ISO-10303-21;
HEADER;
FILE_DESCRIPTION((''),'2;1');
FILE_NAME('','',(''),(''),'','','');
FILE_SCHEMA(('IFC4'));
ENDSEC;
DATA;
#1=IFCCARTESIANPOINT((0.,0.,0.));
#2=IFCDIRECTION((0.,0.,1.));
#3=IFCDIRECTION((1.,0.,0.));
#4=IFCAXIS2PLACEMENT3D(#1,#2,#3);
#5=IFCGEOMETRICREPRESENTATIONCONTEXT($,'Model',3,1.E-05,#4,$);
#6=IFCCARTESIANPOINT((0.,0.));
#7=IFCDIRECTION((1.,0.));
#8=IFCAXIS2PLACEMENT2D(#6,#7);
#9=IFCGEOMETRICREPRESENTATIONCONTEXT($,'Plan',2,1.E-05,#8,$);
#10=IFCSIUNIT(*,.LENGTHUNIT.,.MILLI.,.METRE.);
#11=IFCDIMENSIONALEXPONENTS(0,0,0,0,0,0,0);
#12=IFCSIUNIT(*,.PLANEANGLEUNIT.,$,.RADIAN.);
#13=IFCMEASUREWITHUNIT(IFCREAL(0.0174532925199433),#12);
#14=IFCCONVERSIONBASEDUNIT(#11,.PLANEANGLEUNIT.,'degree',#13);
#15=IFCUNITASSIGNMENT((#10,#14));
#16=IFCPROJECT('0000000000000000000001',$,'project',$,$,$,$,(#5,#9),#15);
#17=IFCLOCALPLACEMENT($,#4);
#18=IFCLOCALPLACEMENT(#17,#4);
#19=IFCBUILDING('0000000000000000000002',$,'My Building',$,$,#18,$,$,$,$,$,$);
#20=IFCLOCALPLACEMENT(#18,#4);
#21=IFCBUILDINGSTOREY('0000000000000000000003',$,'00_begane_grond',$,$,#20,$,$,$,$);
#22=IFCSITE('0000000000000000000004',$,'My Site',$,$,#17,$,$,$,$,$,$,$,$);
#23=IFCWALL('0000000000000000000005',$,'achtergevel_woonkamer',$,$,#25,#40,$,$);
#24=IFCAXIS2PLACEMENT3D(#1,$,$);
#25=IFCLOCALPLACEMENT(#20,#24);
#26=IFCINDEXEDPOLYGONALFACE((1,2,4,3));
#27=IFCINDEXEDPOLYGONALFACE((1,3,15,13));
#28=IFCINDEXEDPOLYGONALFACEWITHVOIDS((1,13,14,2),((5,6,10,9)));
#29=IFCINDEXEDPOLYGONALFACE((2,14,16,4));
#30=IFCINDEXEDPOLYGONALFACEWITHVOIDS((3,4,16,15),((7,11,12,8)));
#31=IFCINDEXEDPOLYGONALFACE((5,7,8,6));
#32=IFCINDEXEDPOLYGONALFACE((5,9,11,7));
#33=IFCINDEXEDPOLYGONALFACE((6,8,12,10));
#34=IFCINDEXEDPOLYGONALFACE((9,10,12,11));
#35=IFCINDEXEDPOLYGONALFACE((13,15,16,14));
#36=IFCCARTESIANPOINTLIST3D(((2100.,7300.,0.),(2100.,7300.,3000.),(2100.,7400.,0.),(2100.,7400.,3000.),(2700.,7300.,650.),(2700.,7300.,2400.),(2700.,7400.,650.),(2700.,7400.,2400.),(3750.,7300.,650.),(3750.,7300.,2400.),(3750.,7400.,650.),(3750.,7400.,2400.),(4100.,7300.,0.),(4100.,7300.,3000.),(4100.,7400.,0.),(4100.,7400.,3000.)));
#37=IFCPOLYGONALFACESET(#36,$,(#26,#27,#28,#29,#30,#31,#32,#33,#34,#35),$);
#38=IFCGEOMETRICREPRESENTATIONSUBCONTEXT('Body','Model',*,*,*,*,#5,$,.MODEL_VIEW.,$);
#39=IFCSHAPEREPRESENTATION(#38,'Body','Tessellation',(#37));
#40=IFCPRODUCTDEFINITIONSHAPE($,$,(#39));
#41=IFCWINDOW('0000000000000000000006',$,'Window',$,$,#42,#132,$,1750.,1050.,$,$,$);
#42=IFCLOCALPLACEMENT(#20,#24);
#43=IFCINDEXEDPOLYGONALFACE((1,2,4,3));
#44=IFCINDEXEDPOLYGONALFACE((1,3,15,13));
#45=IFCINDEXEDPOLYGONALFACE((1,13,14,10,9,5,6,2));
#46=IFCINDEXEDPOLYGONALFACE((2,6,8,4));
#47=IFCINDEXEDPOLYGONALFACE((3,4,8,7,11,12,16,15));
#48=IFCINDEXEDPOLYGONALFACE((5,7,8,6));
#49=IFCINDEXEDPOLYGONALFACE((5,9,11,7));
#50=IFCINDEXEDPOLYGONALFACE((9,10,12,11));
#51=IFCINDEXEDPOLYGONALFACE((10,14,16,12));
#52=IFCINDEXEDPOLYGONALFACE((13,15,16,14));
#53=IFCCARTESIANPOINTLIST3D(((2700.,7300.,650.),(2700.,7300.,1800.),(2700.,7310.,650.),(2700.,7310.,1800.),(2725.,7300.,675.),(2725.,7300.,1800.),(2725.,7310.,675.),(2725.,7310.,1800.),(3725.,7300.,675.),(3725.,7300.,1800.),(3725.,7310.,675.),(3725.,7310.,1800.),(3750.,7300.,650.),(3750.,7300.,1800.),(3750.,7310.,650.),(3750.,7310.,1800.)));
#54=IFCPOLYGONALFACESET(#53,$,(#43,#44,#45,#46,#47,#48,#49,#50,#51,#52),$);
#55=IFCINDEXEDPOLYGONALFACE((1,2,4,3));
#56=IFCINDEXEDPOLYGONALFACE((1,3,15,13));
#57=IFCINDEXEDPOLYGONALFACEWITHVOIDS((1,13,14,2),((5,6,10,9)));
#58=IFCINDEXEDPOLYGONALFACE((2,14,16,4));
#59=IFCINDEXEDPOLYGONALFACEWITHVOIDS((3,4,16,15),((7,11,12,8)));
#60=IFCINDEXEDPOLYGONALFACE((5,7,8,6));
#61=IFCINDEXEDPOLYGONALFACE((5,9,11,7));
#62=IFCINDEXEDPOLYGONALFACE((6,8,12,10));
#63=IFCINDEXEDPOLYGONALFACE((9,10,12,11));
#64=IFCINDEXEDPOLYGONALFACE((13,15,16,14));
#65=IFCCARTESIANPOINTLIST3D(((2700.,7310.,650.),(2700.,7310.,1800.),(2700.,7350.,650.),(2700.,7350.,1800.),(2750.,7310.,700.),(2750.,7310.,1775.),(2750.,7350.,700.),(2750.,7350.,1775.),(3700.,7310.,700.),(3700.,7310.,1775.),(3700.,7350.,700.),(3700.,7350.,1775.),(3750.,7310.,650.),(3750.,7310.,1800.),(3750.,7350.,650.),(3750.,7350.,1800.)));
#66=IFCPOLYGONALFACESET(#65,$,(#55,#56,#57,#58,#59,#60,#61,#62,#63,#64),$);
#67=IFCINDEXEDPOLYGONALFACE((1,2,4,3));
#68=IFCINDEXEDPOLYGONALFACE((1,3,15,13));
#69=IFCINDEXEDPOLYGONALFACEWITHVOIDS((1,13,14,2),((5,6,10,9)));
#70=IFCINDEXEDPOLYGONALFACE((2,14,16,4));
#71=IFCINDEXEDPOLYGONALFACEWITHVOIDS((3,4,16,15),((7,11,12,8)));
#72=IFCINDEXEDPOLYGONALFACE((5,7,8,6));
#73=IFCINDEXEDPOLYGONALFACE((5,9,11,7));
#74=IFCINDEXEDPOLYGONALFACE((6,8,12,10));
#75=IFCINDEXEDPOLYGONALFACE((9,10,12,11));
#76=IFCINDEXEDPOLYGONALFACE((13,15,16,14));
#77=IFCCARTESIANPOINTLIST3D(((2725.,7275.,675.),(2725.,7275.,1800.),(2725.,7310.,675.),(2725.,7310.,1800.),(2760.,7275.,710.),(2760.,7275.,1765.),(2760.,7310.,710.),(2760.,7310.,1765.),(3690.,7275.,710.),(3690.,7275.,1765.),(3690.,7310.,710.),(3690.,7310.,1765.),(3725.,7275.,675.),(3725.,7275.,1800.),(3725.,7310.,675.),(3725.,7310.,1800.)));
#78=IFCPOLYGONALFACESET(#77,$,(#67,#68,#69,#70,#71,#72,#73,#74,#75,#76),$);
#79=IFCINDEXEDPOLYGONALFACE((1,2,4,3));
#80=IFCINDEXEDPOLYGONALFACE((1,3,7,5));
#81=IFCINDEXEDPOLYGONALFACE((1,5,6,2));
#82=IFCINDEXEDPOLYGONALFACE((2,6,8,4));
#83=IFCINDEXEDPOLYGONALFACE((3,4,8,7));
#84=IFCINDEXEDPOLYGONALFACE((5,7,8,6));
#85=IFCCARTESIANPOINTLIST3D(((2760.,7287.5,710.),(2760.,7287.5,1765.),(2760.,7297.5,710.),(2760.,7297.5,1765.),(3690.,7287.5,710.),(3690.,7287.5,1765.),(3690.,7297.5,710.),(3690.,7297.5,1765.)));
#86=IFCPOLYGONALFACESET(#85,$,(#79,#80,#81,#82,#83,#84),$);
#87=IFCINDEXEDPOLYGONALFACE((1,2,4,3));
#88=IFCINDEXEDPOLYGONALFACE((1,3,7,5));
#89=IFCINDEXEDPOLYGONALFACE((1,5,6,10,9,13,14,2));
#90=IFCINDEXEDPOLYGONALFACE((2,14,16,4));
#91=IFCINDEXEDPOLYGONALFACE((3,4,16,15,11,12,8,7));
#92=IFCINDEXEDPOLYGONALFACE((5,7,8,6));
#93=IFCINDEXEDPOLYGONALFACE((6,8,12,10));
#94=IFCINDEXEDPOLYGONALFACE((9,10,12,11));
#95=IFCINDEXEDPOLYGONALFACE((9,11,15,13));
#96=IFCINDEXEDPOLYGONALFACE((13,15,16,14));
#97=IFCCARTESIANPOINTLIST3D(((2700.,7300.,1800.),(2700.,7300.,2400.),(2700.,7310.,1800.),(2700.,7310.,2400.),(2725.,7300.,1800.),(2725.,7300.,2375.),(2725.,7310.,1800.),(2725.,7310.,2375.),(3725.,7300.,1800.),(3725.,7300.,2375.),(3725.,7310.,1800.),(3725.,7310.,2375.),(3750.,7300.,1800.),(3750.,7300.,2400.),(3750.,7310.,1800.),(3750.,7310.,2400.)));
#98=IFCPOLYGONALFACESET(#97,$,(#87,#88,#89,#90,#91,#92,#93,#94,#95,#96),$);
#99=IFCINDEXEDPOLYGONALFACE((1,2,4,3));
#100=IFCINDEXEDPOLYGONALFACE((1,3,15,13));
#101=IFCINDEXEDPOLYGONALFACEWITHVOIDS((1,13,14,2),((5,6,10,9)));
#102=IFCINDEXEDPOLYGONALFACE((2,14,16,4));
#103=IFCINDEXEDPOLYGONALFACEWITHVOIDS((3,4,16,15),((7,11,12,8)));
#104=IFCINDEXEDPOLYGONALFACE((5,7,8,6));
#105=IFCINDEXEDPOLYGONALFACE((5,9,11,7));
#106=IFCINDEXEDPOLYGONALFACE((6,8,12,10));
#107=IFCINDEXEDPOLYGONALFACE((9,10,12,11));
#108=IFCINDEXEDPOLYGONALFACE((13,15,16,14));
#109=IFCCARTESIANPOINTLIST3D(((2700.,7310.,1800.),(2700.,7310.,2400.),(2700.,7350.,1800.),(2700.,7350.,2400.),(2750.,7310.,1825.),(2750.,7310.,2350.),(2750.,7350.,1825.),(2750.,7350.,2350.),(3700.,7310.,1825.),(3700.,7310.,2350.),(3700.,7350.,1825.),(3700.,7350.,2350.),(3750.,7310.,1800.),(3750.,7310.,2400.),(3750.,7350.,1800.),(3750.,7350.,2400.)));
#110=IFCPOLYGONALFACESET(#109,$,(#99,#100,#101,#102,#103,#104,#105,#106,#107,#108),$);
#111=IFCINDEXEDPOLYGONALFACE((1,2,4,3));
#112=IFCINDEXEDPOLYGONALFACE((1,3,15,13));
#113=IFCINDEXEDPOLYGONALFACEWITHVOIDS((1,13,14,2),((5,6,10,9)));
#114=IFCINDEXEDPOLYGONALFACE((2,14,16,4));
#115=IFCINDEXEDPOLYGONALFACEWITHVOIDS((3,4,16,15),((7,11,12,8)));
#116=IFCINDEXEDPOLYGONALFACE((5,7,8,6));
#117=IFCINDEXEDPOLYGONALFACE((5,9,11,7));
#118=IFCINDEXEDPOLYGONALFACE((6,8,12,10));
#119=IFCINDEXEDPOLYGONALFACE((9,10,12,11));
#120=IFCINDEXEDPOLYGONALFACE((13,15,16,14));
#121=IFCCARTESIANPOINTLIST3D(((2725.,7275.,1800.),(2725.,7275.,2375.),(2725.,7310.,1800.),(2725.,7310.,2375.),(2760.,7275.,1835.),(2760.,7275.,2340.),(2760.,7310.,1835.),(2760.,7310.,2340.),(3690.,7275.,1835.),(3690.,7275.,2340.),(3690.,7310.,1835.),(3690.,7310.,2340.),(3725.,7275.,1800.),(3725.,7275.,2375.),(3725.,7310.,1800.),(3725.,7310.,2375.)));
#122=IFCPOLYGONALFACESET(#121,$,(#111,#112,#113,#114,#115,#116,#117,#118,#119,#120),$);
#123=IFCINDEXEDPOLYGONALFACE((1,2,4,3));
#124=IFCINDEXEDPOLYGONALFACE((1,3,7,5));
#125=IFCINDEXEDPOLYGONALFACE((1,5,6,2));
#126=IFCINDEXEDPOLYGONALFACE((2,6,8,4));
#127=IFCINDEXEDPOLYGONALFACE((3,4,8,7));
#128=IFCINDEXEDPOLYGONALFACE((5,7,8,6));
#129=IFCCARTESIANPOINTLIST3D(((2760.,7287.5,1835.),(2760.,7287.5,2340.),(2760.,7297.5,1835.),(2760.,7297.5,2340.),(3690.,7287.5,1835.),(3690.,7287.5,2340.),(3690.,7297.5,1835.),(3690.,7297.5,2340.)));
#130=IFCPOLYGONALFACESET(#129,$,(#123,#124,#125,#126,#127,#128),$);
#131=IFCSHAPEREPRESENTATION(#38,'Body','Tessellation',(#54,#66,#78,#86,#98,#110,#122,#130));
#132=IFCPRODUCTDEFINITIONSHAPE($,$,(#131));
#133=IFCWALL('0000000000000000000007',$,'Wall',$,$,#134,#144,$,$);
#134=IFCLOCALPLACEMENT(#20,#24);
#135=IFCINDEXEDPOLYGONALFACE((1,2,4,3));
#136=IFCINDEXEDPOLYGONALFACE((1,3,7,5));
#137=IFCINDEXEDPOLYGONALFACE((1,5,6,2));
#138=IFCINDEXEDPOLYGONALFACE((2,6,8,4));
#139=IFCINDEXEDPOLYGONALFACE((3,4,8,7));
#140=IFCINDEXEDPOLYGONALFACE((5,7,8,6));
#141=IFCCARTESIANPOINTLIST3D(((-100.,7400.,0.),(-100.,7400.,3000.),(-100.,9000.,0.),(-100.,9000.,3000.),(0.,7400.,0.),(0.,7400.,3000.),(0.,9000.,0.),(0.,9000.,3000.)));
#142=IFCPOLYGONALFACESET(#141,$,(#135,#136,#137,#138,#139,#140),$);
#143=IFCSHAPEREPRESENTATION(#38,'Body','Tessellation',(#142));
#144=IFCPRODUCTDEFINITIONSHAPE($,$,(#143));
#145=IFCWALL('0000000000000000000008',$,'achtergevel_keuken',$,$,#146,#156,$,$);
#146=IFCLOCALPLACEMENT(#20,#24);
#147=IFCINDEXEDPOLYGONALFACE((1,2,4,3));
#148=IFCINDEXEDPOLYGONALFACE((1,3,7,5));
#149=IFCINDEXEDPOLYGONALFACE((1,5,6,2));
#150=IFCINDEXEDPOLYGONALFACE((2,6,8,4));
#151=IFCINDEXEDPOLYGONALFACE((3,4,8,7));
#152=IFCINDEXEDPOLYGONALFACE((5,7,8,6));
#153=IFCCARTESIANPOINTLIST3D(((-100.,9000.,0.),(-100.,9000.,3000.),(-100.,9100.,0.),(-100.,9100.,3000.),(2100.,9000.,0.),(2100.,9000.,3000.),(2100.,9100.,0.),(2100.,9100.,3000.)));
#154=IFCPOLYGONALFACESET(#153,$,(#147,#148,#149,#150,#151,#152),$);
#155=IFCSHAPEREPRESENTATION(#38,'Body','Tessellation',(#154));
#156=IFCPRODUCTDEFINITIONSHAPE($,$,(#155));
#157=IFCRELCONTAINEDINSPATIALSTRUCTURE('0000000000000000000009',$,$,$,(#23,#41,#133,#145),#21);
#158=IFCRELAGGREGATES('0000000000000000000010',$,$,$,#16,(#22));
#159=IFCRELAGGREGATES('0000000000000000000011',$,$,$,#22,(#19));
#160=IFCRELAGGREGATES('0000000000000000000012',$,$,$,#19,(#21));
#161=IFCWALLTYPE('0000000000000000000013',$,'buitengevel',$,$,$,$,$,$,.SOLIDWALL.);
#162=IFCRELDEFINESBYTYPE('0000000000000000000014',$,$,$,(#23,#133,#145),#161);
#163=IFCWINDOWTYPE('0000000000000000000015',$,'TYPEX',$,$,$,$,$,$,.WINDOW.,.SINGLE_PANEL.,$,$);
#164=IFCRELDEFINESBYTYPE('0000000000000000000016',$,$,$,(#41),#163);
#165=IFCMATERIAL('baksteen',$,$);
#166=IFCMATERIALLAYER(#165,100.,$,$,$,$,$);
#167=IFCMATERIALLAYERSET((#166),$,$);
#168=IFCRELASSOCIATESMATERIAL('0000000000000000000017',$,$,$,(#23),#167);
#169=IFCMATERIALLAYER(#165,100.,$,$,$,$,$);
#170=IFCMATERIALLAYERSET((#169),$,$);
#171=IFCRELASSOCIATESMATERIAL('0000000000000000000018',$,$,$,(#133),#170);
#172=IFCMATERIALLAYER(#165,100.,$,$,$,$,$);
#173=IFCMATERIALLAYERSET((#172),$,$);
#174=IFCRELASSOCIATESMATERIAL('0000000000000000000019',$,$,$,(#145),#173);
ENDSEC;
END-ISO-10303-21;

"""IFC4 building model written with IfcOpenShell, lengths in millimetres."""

from ifc_helpers import new_model, entity, si_unit, converted_unit, frame, origin_with_axes, origin_2d_with_axis, place, context, subcontext, project, spatial, line, indexed_curve, outline, extrude, shape, source, transform, mapped, material, layer, layer_set, type_object, type_shapes, element, fill, save


model = new_model("IFC4")

# Units and contexts
model_context = context("Model", 3, precision=1e-05, world=origin_with_axes())
plan_context = context("Plan", 2, precision=1e-05, world=origin_2d_with_axis())
body_context_1 = subcontext(model_context, "Body", "Model", "MODEL_VIEW")
body_context_2 = subcontext(plan_context, "Body", "Plan", "PLAN_VIEW")
ifc_project = project(units=[si_unit("LENGTHUNIT", "METRE", prefix="MILLI"), converted_unit("PLANEANGLEUNIT", "degree", entity("IfcReal", 0.0174532925199433), si_unit("PLANEANGLEUNIT", "RADIAN"), dimensions=[0, 0, 0, 0, 0, 0, 0])], contexts=[model_context, plan_context])

# Site, building, storey
site_placement = place(None, origin_with_axes())
site = spatial("IfcSite", under=ifc_project, at=site_placement, Name="My Site")
building_placement = place(site_placement, origin_with_axes())
building = spatial("IfcBuilding", under=site, at=building_placement, Name="My Building")
storey_placement = place(building_placement, origin_with_axes())
storey = spatial("IfcBuildingStorey", under=building, at=storey_placement, Name="00_begane_grond")

# Wall, opening, window
ifc_material_1 = material(Name="baksteen")
ifc_layer_1 = layer(ifc_material_1, 100.0)
ifc_layer_set_1 = layer_set([ifc_layer_1])
wall_type_1 = type_object("IfcWallType", Name="buitengevel", PredefinedType="SOLIDWALL")
wall_1_placement = place(storey_placement, frame((4100.0, 7400.0, 0.0), z_axis=(0.0, 0.0, 1.0), x_axis=(-1.0, 0.0, 0.0)))
wall_1 = element("IfcWall", 1, at=wall_1_placement, inside=storey, type_object=wall_type_1, material=ifc_layer_set_1, Name="achtergevel_woonkamer", context=body_context_1, shape_type="SweptSolid", body=[
    extrude(outline(indexed_curve([(0.0, 0.0), (0.0, 100.0), (2000.0, 100.0), (2000.0, 0.0), (0.0, 0.0)], self_intersect=False)), origin_with_axes(), (0.0, 0.0, 1.0), 3000.0),
])
shared_shape_1 = source(origin_with_axes(), body_context_1, "Body", "SweptSolid", [
    extrude(outline(indexed_curve([(0.0, 0.0), (1050.0, 0.0), (1050.0, 1750.0), (0.0, 1750.0)], segments=[line(1, 2, 3, 4, 1)])), frame((0.0, -100.0, 0.0), z_axis=(0.0, -1.0, 0.0), x_axis=(1.0, 0.0, 0.0)), (0.0, 0.0, -1.0), 300.0),
])
opening_1_placement = place(wall_1_placement, frame((350.0, 0.0, 650.0), z_axis=(0.0, 0.0, 1.0), x_axis=(1.0, 0.0, 0.0)))
opening_1 = element("IfcOpeningElement", 2, at=opening_1_placement, cuts=wall_1, PredefinedType="OPENING", context=body_context_1, shape_type="MappedRepresentation", body=[
    mapped(shared_shape_1, transform((0.0, 0.0, 0.0), x_axis=(1.0, 0.0, 0.0), y_axis=(0.0, 1.0, 0.0), z_axis=(0.0, 0.0, 1.0), scale=1.0)),
])
window_type_1 = type_object("IfcWindowType", Name="TYPEX", PartitioningType="SINGLE_PANEL", PredefinedType="WINDOW")
shared_shape_2 = source(origin_with_axes(), body_context_1, "Body", "SweptSolid", [
    extrude(outline(indexed_curve([(1050.0, 1150.0), (1050.0, 0.0), (0.0, 0.0), (0.0, 1150.0), (25.0, 1150.0), (25.0, 25.0), (1025.0, 25.0), (1025.0, 1150.0)], segments=[line(1, 2, 3, 4, 5, 6, 7, 8, 1)])), frame((0.0, 90.0, 0.0), z_axis=(0.0, -1.0, 0.0), x_axis=(1.0, 0.0, 0.0)), (0.0, 0.0, -1.0), 10.0),
    extrude(outline(indexed_curve([(0.0, 0.0), (1050.0, 0.0), (1050.0, 1150.0), (0.0, 1150.0)], segments=[line(1, 2, 3, 4, 1)]), holes=[indexed_curve([(50.0, 50.0), (1000.0, 50.0), (1000.0, 1125.0), (50.0, 1125.0)], segments=[line(1, 2, 3, 4, 1)])]), frame((0.0, 50.0, 0.0), z_axis=(0.0, -1.0, 0.0), x_axis=(1.0, 0.0, 0.0)), (0.0, 0.0, -1.0), 40.0),
    extrude(outline(indexed_curve([(0.0, 0.0), (1000.0, 0.0), (1000.0, 1125.0), (0.0, 1125.0)], segments=[line(1, 2, 3, 4, 1)]), holes=[indexed_curve([(35.0, 35.0), (965.0, 35.0), (965.0, 1090.0), (35.0, 1090.0)], segments=[line(1, 2, 3, 4, 1)])]), frame((25.0, 90.0, 25.0), z_axis=(0.0, -1.0, 0.0), x_axis=(1.0, 0.0, 0.0)), (0.0, 0.0, -1.0), 35.0),
    extrude(outline(indexed_curve([(35.0, 35.0), (965.0, 35.0), (965.0, 1090.0), (35.0, 1090.0)], segments=[line(1, 2, 3, 4, 1)])), frame((25.0, 102.5, 25.0), z_axis=(0.0, -1.0, 0.0), x_axis=(1.0, 0.0, 0.0)), (0.0, 0.0, -1.0), 10.0),
    extrude(outline(indexed_curve([(0.0, 0.0), (0.0, 600.0), (1050.0, 600.0), (1050.0, 0.0), (1025.0, 0.0), (1025.0, 575.0), (25.0, 575.0), (25.0, 0.0)], segments=[line(1, 2, 3, 4, 5, 6, 7, 8, 1)])), frame((0.0, 90.0, 1150.0), z_axis=(0.0, -1.0, 0.0), x_axis=(1.0, 0.0, 0.0)), (0.0, 0.0, -1.0), 10.0),
    extrude(outline(indexed_curve([(0.0, 0.0), (1050.0, 0.0), (1050.0, 600.0), (0.0, 600.0)], segments=[line(1, 2, 3, 4, 1)]), holes=[indexed_curve([(50.0, 25.0), (1000.0, 25.0), (1000.0, 550.0), (50.0, 550.0)], segments=[line(1, 2, 3, 4, 1)])]), frame((0.0, 50.0, 1150.0), z_axis=(0.0, -1.0, 0.0), x_axis=(1.0, 0.0, 0.0)), (0.0, 0.0, -1.0), 40.0),
    extrude(outline(indexed_curve([(0.0, 0.0), (1000.0, 0.0), (1000.0, 575.0), (0.0, 575.0)], segments=[line(1, 2, 3, 4, 1)]), holes=[indexed_curve([(35.0, 35.0), (965.0, 35.0), (965.0, 540.0), (35.0, 540.0)], segments=[line(1, 2, 3, 4, 1)])]), frame((25.0, 90.0, 1150.0), z_axis=(0.0, -1.0, 0.0), x_axis=(1.0, 0.0, 0.0)), (0.0, 0.0, -1.0), 35.0),
    extrude(outline(indexed_curve([(35.0, 35.0), (965.0, 35.0), (965.0, 540.0), (35.0, 540.0)], segments=[line(1, 2, 3, 4, 1)])), frame((25.0, 102.5, 1150.0), z_axis=(0.0, -1.0, 0.0), x_axis=(1.0, 0.0, 0.0)), (0.0, 0.0, -1.0), 10.0),
])
shared_shape_3 = source(origin_with_axes(), body_context_2, "Body", "Curve2D", [
    entity("IfcIndexedPolyCurve", entity("IfcCartesianPointList2D", [[50.0, 50.0], [1000.0, 50.0]])),
    entity("IfcIndexedPolyCurve", entity("IfcCartesianPointList2D", [[0.0, 100.0], [25.0, 100.0], [25.0, 90.0], [50.0, 90.0], [50.0, 50.0], [0.0, 50.0]]), [entity("IfcLineIndex", [1, 2, 3, 4, 5, 6, 1])]),
    entity("IfcIndexedPolyCurve", entity("IfcCartesianPointList2D", [[1050.0, 100.0], [1025.0, 100.0], [1025.0, 90.0], [1000.0, 90.0], [1000.0, 50.0], [1050.0, 50.0]]), [entity("IfcLineIndex", [1, 2, 3, 4, 5, 6, 1])]),
    entity("IfcIndexedPolyCurve", entity("IfcCartesianPointList2D", [[25.0, 90.0], [60.0, 90.0], [60.0, 125.0], [25.0, 125.0]]), [entity("IfcLineIndex", [1, 2, 3, 4, 1])]),
    entity("IfcIndexedPolyCurve", entity("IfcCartesianPointList2D", [[1025.0, 90.0], [990.0, 90.0], [990.0, 125.0], [1025.0, 125.0]]), [entity("IfcLineIndex", [1, 2, 3, 4, 1])]),
    entity("IfcIndexedPolyCurve", entity("IfcCartesianPointList2D", [[60.0, 90.0], [990.0, 90.0]])),
    entity("IfcIndexedPolyCurve", entity("IfcCartesianPointList2D", [[60.0, 125.0], [990.0, 125.0]])),
    entity("IfcIndexedPolyCurve", entity("IfcCartesianPointList2D", [[60.0, 107.5], [990.0, 107.5]])),
])
type_shapes(window_type_1, [shared_shape_2, shared_shape_3])
window_1_placement = place(opening_1_placement, frame((0.0, 0.0, 0.0), z_axis=(0.0, 0.0, 1.0), x_axis=(1.0, 0.0, 0.0)))
window_1 = element("IfcWindow", 3, at=window_1_placement, inside=storey, type_object=window_type_1, Name="Window", OverallHeight=1750.0, OverallWidth=1050.0, shapes=[
    shape(body_context_1, "Body", "MappedRepresentation", [mapped(shared_shape_2, transform((0.0, 0.0, 0.0), x_axis=(1.0, 0.0, 0.0), y_axis=(0.0, 1.0, 0.0), z_axis=(0.0, 0.0, 1.0), scale=1.0))]),
    shape(body_context_2, "Body", "MappedRepresentation", [mapped(shared_shape_3, transform((0.0, 0.0, 0.0), x_axis=(1.0, 0.0, 0.0), y_axis=(0.0, 1.0, 0.0), z_axis=(0.0, 0.0, 1.0), scale=1.0))]),
])
fill(opening_1, window_1)

# Walls
ifc_layer_2 = layer(ifc_material_1, 100.0)
ifc_layer_set_2 = layer_set([ifc_layer_2])
wall_2_placement = place(storey_placement, frame((0.0, 7400.0, 0.0), z_axis=(0.0, 0.0, 1.0), x_axis=(0.000001, 1.0, 0.0)))
element("IfcWall", 4, at=wall_2_placement, inside=storey, type_object=wall_type_1, material=ifc_layer_set_2, Name="Wall", context=body_context_1, shape_type="SweptSolid", body=[
    extrude(outline(indexed_curve([(0.0, 0.0), (0.0, 100.0), (1600.0, 100.0), (1600.0, 0.0), (0.0, 0.0)], self_intersect=False)), origin_with_axes(), (0.0, 0.0, 1.0), 3000.0),
])
ifc_layer_3 = layer(ifc_material_1, 100.0)
ifc_layer_set_3 = layer_set([ifc_layer_3])
wall_3_placement = place(storey_placement, frame((-100.0, 9000.0, 0.0), z_axis=(0.0, 0.0, 1.0), x_axis=(1.0, -0.000001, 0.0)))
element("IfcWall", 5, at=wall_3_placement, inside=storey, type_object=wall_type_1, material=ifc_layer_set_3, Name="achtergevel_keuken", context=body_context_1, shape_type="SweptSolid", body=[
    extrude(outline(indexed_curve([(0.0, 0.0), (0.0, 100.0), (2200.0, 100.0), (2200.0, 0.0), (0.0, 0.0)], self_intersect=False)), origin_with_axes(), (0.0, 0.0, 1.0), 3000.0),
])

save(model, "model.ifc")
